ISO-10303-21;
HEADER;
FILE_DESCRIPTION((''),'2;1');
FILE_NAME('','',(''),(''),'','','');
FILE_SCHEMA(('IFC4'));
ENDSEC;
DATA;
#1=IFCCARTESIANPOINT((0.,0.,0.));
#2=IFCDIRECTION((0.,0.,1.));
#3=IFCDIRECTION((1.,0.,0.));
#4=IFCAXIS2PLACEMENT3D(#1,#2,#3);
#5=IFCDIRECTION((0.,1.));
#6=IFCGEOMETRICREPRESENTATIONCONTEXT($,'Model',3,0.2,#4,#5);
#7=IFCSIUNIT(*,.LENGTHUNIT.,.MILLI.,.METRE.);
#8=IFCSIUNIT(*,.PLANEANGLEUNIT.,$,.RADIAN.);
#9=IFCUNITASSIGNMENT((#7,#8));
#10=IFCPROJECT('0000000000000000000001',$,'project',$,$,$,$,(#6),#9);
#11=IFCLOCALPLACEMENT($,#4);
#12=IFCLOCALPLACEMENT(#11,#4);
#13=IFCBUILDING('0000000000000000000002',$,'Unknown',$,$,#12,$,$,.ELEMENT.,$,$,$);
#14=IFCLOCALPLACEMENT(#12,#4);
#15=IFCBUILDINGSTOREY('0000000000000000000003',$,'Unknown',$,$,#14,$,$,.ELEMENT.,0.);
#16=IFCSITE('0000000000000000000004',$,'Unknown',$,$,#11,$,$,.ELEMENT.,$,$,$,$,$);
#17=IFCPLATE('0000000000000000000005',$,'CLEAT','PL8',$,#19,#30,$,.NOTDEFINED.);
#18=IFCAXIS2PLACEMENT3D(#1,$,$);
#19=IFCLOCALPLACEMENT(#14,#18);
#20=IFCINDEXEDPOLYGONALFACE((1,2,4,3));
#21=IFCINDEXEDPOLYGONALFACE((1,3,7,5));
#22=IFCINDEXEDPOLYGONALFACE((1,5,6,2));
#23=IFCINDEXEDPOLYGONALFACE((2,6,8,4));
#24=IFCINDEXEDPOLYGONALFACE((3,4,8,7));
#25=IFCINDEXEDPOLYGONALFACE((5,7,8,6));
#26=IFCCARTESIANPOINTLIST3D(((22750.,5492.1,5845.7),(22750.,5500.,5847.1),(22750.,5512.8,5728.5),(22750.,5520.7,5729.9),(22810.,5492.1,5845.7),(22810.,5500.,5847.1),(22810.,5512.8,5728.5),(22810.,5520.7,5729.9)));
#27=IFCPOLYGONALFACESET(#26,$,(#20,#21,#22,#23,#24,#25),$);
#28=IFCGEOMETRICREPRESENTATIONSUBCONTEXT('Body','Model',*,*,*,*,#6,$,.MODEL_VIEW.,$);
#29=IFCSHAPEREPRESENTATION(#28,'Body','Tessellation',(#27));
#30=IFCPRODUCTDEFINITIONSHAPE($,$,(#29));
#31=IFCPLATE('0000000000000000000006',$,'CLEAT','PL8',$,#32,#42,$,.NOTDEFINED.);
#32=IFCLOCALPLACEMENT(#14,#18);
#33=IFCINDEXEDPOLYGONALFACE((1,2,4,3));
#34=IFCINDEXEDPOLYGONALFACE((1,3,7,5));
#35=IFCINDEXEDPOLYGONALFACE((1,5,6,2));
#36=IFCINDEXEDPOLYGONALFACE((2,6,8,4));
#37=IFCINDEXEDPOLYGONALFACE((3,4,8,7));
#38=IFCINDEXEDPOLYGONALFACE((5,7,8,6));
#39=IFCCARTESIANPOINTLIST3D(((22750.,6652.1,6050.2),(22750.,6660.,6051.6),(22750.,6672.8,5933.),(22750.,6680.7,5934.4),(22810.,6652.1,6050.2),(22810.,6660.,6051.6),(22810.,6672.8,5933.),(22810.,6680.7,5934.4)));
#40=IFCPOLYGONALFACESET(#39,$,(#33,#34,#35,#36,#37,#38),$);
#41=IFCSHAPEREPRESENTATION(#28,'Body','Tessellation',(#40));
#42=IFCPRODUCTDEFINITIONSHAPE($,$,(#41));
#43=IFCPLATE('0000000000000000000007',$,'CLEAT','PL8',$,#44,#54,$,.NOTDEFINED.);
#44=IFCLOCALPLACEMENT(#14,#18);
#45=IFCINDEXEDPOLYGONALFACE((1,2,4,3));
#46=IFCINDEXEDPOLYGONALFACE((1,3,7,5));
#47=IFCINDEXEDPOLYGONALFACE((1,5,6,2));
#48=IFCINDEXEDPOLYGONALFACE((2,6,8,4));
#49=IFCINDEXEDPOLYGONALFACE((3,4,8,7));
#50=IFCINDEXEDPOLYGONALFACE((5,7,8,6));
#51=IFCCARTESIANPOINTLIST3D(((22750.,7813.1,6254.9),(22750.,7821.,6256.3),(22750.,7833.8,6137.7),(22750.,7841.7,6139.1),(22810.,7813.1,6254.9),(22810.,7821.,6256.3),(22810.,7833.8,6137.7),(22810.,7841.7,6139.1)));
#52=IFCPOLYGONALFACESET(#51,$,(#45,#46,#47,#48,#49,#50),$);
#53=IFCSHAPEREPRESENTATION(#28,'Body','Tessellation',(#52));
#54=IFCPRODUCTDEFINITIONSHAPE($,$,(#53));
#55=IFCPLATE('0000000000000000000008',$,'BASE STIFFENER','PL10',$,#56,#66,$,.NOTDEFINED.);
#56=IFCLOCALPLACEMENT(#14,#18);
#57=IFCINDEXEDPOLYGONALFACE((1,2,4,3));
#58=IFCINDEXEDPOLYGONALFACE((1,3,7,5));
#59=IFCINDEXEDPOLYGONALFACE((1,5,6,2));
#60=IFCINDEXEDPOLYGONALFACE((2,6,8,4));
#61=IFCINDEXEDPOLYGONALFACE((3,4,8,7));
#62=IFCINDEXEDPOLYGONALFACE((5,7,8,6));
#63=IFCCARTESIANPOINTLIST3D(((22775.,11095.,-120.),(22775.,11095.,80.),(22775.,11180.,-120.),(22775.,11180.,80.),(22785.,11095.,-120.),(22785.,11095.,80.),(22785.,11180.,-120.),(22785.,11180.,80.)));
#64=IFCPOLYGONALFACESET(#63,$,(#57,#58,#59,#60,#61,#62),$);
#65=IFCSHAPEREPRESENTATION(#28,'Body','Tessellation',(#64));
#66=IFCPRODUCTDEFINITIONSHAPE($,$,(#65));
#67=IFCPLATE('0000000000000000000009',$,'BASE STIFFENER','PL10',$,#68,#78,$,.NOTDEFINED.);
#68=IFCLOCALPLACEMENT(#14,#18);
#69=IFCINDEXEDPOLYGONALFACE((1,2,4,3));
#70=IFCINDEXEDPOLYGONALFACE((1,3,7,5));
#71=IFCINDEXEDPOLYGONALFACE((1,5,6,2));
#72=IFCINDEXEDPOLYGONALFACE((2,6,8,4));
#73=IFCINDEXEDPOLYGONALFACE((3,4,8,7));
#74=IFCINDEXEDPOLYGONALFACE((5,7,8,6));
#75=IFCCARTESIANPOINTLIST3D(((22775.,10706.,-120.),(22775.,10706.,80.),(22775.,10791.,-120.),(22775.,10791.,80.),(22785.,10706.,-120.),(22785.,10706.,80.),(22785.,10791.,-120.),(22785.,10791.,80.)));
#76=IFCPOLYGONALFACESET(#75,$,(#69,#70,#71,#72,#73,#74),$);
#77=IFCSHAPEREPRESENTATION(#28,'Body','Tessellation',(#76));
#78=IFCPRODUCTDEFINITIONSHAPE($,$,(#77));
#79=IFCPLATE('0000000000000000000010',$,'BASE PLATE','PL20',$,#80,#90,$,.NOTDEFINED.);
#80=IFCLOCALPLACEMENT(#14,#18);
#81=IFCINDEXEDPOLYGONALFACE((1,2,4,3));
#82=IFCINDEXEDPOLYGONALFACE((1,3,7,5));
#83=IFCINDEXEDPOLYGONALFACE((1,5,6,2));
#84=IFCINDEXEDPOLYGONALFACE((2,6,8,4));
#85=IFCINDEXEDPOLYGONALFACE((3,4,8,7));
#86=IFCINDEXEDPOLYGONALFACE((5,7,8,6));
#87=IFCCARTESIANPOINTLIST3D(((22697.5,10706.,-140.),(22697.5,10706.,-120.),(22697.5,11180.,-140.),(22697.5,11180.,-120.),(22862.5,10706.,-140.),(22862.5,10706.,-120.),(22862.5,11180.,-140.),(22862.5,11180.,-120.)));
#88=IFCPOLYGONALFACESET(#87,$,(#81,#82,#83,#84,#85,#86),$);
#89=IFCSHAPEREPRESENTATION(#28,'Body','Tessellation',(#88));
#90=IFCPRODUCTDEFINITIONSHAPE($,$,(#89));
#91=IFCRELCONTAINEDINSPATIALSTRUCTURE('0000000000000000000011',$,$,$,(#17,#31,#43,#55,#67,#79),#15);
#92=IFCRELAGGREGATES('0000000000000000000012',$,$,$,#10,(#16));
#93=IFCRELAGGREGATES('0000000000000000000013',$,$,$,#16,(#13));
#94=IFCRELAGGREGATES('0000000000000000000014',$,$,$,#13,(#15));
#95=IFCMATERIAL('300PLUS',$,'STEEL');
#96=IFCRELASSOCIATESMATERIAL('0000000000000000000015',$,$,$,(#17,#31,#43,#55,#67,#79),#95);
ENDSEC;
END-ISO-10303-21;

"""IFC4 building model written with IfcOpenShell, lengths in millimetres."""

from ifc_helpers import new_model, si_unit, direction, frame, origin_with_axes, place, context, subcontext, project, spatial, line, indexed_curve, outline, extrude, material, element, save


model = new_model("IFC4")

# Units and contexts
model_context = context("Model", 3, precision=0.2, world=origin_with_axes(), true_north=direction((0.0, 1.0)))
body_context = subcontext(model_context, "Body", "Model", "MODEL_VIEW")
ifc_project = project(units=[si_unit("LENGTHUNIT", "METRE", prefix="MILLI"), si_unit("PLANEANGLEUNIT", "RADIAN")], contexts=[model_context])

# Site, building, storey
site_placement = place(None, origin_with_axes())
site = spatial("IfcSite", under=ifc_project, at=site_placement, Name="Unknown", CompositionType="ELEMENT")
building_placement = place(site_placement, origin_with_axes())
building = spatial("IfcBuilding", under=site, at=building_placement, Name="Unknown", CompositionType="ELEMENT")
storey_placement = place(building_placement, origin_with_axes())
storey = spatial("IfcBuildingStorey", under=building, at=storey_placement, Name="Unknown", CompositionType="ELEMENT", Elevation=0.0)

# Shared definitions
ifc_material_1 = material(Name="300PLUS", Category="STEEL")

# Plates
for number, where, z_axis, x_axis, name in (
    (1, (22810.0, 5516.7, 5729.2), (0.0, 0.984758, 0.173929), (-1.0, 0.0, 0.0), "CLEAT"),
    (2, (22810.0, 6676.7, 5933.7), (0.0, 0.984758, 0.173929), (-1.0, 0.0, 0.0), "CLEAT"),
    (3, (22810.0, 7837.7, 6138.4), (0.0, 0.984758, 0.173929), (-1.0, 0.0, 0.0), "CLEAT"),
):
    element("IfcPlate", number, at=place(storey_placement, frame(where, z_axis=z_axis, x_axis=x_axis)), inside=storey, material=ifc_material_1, Name=name, Description="PL8", PredefinedType="NOTDEFINED", context=body_context, shape_type="SolidModel", body=[
        extrude(outline(indexed_curve([(0.0, 0.0), (60.0, 0.0), (60.0, 119.0), (0.0, 119.0)], segments=[line(1, 2, 3, 4, 1)])), frame((0.0, 0.0, 4.0), z_axis=(0.0, 0.0, 1.0), x_axis=(1.0, 0.0, 0.0)), (0.0, 0.0, -1.0), 8.0),
    ])
for number, where, z_axis, x_axis, name in (
    (4, (22780.0, 11095.0, -120.0), (1.0, 0.0, 0.0), (0.0, 1.0, 0.0), "BASE STIFFENER"),
    (5, (22780.0, 10706.0, -120.0), (1.0, 0.0, 0.0), (0.0, 1.0, 0.0), "BASE STIFFENER"),
):
    element("IfcPlate", number, at=place(storey_placement, frame(where, z_axis=z_axis, x_axis=x_axis)), inside=storey, material=ifc_material_1, Name=name, Description="PL10", PredefinedType="NOTDEFINED", context=body_context, shape_type="SolidModel", body=[
        extrude(outline(indexed_curve([(0.0, 0.0), (85.0, 0.0), (85.0, 200.0), (0.0, 200.0)], segments=[line(1, 2, 3, 4, 1)])), frame((0.0, 0.0, 5.0), z_axis=(0.0, 0.0, 1.0), x_axis=(1.0, 0.0, 0.0)), (0.0, 0.0, -1.0), 10.0),
    ])
plate_placement = place(storey_placement, frame((22697.5, 10706.0, -130.0), z_axis=(0.0, 0.0, 1.0), x_axis=(1.0, 0.0, 0.0)))
element("IfcPlate", 6, at=plate_placement, inside=storey, material=ifc_material_1, Name="BASE PLATE", Description="PL20", PredefinedType="NOTDEFINED", context=body_context, shape_type="SolidModel", body=[
    extrude(outline(indexed_curve([(0.0, 0.0), (165.0, 0.0), (165.0, 474.0), (0.0, 474.0)], segments=[line(1, 2, 3, 4, 1)])), frame((0.0, 0.0, 10.0), z_axis=(0.0, 0.0, 1.0), x_axis=(1.0, 0.0, 0.0)), (0.0, 0.0, -1.0), 20.0),
])

save(model, "model.ifc")
